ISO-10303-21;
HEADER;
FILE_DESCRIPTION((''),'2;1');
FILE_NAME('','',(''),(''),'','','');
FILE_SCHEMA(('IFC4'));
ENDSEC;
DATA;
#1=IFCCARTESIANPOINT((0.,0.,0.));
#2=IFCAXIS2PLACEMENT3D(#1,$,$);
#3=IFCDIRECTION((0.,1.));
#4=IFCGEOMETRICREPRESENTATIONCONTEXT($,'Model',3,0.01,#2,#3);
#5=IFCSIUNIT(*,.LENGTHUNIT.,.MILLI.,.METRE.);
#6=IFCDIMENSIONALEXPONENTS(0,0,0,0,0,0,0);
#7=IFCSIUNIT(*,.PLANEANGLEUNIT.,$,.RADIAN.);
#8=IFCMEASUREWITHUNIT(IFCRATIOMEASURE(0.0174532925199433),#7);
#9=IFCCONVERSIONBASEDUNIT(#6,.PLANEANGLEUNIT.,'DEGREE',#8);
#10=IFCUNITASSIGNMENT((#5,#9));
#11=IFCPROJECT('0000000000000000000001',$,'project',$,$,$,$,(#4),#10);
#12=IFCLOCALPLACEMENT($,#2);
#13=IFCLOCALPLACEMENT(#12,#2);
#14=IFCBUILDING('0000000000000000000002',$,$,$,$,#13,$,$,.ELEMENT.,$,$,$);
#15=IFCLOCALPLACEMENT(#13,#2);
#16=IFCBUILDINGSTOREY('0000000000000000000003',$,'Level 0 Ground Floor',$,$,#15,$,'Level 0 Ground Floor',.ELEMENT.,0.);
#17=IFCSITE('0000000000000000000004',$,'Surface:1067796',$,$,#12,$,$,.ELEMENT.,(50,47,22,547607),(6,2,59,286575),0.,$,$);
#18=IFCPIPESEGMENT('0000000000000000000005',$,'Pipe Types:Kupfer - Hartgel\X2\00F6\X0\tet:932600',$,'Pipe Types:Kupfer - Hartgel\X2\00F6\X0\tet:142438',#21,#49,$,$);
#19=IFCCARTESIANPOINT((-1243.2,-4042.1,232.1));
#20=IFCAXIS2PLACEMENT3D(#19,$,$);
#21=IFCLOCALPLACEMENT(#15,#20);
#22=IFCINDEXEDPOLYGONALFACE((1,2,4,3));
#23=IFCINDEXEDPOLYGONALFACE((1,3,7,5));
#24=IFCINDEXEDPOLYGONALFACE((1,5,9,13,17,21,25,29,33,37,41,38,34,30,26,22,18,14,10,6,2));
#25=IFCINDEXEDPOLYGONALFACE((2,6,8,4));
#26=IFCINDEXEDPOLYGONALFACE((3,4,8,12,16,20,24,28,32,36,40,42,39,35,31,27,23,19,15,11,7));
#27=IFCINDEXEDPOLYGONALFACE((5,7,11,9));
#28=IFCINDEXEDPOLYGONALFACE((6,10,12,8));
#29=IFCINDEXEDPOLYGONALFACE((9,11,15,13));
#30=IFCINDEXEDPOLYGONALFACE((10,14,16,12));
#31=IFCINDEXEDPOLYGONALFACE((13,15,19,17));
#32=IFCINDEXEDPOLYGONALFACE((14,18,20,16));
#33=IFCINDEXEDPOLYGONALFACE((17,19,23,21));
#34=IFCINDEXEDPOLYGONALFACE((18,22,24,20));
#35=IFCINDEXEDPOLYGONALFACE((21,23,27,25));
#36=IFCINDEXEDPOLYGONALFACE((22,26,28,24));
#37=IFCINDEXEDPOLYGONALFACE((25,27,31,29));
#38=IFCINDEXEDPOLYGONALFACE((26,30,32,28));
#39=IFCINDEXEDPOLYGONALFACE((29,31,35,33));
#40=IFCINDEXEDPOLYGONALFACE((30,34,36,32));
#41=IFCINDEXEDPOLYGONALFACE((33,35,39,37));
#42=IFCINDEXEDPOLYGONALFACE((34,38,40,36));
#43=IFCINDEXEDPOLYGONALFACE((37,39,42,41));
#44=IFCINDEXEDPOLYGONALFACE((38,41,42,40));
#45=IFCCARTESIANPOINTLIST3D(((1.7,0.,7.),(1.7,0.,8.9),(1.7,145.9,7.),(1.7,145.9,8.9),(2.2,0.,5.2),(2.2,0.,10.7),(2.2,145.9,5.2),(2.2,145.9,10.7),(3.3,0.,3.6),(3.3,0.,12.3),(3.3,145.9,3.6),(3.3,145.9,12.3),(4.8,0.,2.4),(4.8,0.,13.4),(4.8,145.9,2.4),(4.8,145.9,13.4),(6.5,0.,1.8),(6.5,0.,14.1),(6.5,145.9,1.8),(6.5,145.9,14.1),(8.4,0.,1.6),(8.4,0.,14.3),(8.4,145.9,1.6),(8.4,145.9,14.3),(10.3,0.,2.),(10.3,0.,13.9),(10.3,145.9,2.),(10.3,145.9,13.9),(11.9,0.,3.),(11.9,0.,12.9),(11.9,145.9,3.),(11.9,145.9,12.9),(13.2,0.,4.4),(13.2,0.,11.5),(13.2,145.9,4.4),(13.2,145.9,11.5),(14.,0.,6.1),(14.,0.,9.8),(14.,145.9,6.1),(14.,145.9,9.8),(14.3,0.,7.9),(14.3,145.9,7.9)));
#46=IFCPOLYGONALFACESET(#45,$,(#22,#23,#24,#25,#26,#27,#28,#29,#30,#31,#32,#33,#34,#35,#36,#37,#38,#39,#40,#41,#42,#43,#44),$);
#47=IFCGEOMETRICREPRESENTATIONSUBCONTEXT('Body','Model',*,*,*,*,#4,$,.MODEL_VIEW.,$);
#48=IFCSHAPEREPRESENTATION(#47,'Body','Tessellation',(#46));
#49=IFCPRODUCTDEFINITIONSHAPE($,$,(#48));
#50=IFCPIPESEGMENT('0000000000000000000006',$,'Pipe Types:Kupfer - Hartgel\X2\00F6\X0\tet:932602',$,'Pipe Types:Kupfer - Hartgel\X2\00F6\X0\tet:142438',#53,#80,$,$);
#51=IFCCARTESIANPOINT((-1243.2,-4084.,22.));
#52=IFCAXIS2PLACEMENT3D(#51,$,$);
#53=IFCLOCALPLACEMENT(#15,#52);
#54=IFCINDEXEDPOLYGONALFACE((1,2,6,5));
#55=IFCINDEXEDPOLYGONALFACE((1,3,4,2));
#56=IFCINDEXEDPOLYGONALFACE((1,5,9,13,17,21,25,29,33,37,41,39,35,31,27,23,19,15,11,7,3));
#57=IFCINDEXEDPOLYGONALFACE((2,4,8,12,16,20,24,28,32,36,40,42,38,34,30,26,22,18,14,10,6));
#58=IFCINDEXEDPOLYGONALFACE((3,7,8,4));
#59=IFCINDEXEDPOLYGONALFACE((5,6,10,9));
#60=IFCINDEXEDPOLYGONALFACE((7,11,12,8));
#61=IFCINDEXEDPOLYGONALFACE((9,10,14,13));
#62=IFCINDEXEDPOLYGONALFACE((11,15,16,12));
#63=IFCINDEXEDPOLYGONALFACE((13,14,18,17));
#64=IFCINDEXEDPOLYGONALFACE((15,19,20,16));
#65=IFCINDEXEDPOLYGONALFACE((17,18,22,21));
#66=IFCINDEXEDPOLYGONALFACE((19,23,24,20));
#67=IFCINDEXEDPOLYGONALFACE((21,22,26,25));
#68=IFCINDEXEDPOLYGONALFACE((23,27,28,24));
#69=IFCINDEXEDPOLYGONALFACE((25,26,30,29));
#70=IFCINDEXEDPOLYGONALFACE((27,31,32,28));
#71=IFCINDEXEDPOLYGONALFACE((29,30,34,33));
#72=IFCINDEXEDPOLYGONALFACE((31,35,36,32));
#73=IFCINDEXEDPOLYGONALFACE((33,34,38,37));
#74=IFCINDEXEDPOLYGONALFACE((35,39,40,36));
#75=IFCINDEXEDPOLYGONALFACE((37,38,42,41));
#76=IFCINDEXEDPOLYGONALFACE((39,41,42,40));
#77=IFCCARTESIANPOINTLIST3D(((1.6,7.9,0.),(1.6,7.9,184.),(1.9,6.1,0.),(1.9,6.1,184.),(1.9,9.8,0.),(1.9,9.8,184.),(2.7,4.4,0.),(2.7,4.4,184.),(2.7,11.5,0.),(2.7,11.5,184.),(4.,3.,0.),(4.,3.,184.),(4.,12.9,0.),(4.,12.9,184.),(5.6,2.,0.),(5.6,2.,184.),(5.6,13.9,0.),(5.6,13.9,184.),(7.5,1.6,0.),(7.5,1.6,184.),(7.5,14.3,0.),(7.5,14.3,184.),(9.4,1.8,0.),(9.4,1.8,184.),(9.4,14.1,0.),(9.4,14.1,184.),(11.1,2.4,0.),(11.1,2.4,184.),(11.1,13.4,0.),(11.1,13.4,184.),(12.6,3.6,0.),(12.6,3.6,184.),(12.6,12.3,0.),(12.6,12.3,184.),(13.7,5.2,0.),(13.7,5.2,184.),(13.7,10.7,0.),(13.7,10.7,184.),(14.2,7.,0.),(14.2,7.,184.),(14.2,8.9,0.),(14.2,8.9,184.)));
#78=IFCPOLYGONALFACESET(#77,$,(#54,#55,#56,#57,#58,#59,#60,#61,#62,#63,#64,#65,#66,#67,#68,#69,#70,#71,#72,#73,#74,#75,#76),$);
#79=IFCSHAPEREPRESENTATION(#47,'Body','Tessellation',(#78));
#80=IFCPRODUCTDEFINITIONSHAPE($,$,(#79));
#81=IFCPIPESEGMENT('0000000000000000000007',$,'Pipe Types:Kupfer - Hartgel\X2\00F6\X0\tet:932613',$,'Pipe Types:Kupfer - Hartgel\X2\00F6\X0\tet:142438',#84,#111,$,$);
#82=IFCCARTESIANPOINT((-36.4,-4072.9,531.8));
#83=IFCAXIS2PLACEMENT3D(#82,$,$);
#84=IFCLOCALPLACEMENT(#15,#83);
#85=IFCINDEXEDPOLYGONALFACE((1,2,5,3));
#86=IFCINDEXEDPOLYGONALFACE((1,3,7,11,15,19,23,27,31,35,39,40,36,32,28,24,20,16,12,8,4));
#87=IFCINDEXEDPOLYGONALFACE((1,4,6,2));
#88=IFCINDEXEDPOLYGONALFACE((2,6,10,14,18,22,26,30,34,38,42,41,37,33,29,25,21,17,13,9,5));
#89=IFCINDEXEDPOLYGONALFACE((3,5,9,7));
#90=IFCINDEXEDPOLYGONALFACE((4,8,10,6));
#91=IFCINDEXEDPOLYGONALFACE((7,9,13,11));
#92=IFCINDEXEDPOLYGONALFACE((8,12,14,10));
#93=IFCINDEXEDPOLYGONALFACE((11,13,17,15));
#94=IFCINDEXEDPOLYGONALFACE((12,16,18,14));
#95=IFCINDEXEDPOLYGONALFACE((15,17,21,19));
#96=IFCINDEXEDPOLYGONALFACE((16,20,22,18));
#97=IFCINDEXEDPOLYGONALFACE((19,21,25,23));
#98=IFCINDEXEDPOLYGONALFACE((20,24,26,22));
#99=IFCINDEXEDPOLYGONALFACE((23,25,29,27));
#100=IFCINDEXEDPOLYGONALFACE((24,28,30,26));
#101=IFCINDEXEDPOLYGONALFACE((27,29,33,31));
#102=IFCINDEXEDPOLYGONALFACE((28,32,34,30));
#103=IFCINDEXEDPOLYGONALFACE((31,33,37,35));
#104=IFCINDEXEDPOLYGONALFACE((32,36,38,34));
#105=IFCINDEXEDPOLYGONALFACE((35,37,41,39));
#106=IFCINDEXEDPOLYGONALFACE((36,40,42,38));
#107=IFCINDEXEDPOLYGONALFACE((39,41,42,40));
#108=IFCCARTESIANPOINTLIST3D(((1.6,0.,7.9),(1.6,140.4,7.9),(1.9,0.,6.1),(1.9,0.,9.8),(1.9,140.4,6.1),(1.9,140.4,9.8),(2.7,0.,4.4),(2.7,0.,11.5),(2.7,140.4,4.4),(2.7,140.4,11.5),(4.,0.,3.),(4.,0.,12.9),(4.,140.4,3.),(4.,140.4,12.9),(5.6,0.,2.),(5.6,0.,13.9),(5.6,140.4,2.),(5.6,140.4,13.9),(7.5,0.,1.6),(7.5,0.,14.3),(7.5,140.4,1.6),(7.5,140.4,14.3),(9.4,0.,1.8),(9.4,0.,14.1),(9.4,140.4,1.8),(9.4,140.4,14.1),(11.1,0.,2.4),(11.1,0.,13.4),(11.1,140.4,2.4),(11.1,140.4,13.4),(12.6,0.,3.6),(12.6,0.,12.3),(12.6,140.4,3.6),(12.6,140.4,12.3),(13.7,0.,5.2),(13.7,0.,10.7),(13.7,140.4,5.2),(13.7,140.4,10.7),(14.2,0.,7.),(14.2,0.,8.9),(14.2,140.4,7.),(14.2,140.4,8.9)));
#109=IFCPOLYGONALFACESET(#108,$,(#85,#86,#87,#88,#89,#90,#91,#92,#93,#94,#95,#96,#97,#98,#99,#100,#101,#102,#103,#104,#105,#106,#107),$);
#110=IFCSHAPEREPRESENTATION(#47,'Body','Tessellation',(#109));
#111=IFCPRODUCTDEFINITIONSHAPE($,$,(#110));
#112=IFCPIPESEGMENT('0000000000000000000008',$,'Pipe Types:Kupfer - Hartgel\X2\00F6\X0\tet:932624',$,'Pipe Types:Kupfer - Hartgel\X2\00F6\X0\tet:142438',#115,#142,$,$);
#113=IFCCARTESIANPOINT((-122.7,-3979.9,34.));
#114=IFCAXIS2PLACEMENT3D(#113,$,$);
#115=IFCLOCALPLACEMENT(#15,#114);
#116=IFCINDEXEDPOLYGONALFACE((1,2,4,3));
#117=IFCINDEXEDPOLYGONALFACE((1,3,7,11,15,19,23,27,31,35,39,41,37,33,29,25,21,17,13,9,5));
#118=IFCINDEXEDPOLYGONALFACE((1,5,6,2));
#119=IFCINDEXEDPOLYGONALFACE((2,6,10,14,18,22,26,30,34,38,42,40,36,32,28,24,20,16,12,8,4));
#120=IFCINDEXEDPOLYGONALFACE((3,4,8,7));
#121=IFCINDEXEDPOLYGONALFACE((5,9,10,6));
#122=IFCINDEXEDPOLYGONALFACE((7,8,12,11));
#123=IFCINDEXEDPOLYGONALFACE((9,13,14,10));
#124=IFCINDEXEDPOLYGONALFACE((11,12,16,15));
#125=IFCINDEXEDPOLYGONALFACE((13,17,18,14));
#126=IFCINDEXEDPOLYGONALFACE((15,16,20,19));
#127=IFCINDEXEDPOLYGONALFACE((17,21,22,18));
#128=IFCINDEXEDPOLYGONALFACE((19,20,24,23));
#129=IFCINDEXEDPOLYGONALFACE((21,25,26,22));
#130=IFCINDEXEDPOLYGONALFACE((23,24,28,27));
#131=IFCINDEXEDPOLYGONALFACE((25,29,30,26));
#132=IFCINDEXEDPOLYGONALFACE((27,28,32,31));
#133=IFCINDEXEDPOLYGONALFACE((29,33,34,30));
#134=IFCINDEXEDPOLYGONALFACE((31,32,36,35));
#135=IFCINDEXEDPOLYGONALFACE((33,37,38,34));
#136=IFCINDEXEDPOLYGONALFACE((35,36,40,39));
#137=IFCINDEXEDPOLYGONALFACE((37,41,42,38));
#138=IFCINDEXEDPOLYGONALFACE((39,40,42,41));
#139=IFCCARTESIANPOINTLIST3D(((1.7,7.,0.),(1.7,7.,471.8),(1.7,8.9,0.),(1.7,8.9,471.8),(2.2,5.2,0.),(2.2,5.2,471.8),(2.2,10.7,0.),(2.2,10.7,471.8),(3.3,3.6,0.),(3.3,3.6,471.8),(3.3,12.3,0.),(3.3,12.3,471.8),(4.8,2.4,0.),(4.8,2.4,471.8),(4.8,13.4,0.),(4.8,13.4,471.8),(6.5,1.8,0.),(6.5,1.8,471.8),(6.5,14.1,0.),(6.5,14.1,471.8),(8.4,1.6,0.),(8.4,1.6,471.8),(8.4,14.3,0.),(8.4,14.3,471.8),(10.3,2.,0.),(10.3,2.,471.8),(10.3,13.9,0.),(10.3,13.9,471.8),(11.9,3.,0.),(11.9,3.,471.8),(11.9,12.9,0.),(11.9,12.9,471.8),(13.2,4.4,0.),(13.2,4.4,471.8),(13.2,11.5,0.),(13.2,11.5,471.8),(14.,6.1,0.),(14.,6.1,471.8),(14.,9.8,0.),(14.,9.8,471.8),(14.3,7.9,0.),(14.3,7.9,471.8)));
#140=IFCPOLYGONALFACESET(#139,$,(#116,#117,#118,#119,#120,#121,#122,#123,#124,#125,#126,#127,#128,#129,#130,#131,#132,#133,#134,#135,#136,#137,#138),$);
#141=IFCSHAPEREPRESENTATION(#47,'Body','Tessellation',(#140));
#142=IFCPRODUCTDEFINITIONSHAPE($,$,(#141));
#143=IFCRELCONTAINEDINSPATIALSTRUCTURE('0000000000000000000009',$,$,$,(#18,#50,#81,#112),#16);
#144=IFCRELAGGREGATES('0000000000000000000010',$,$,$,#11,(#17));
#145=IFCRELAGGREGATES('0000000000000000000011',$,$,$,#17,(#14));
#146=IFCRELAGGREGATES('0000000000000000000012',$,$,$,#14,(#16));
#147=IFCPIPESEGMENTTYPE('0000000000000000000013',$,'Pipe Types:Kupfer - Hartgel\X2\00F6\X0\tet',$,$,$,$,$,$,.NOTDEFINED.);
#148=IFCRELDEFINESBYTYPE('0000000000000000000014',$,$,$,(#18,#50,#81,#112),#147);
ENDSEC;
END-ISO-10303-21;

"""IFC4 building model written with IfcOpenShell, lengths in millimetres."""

from ifc_helpers import new_model, entity, si_unit, converted_unit, direction, frame, frame_2d, origin, origin_2d_with_axis, place, context, subcontext, project, spatial, circle, extrude, type_object, element, save


model = new_model("IFC4")

# Units and contexts
model_context = context("Model", 3, precision=0.01, world=origin(), true_north=direction((0.0, 1.0)))
body_context = subcontext(model_context, "Body", "Model", "MODEL_VIEW")
ifc_project = project(units=[si_unit("LENGTHUNIT", "METRE", prefix="MILLI"), converted_unit("PLANEANGLEUNIT", "DEGREE", entity("IfcRatioMeasure", 0.0174532925199433), si_unit("PLANEANGLEUNIT", "RADIAN"), dimensions=[0, 0, 0, 0, 0, 0, 0])], contexts=[model_context])

# Site, building, storey
site_placement = place(None, origin())
site = spatial("IfcSite", under=ifc_project, at=site_placement, Name="Surface:1067796", CompositionType="ELEMENT", RefLatitude=(50, 47, 22, 547607), RefLongitude=(6, 2, 59, 286575), RefElevation=0.0)
building_placement = place(site_placement, origin())
building = spatial("IfcBuilding", under=site, at=building_placement, CompositionType="ELEMENT")
storey_placement = place(building_placement, origin())
storey = spatial("IfcBuildingStorey", under=building, at=storey_placement, Name="Level 0 Ground Floor", LongName="Level 0 Ground Floor", CompositionType="ELEMENT", Elevation=0.0)

# Pipe segments
pipe_segment_type_1 = type_object("IfcPipeSegmentType", Name="Pipe Types:Kupfer - Hartgelötet", PredefinedType="NOTDEFINED")
pipe_segment_1_placement = place(storey_placement, frame((-1243.2, -4042.1, 232.1)))
element("IfcPipeSegment", 1, at=pipe_segment_1_placement, inside=storey, type_object=pipe_segment_type_1, Name="Pipe Types:Kupfer - Hartgelötet:932600", ObjectType="Pipe Types:Kupfer - Hartgelötet:142438", context=body_context, shape_type="SweptSolid", body=[
    extrude(circle(Radius=6.3, at=frame_2d((0.0, 0.0), x_axis=(1.0, 0.0))), frame((7.9, 0.0, 7.9), z_axis=(0.0, 1.0, 0.0), x_axis=(1.0, 0.0, 0.0)), (0.0, 0.0, 1.0), 145.9),
])
pipe_segment_2_placement = place(storey_placement, frame((-1243.2, -4084.0, 22.0)))
element("IfcPipeSegment", 2, at=pipe_segment_2_placement, inside=storey, type_object=pipe_segment_type_1, Name="Pipe Types:Kupfer - Hartgelötet:932602", ObjectType="Pipe Types:Kupfer - Hartgelötet:142438", context=body_context, shape_type="SweptSolid", body=[
    extrude(circle(Radius=6.3, at=frame_2d((0.0, 0.0), x_axis=(1.0, 0.0))), frame((7.9, 7.9, 0.0), z_axis=(0.0, 0.0, 1.0), x_axis=(-1.0, 0.0, 0.0)), (0.0, 0.0, 1.0), 184.0),
])
pipe_segment_3_placement = place(storey_placement, frame((-36.4, -4072.9, 531.8)))
element("IfcPipeSegment", 3, at=pipe_segment_3_placement, inside=storey, type_object=pipe_segment_type_1, Name="Pipe Types:Kupfer - Hartgelötet:932613", ObjectType="Pipe Types:Kupfer - Hartgelötet:142438", context=body_context, shape_type="SweptSolid", body=[
    extrude(circle(Radius=6.3, at=frame_2d((0.0, 0.0), x_axis=(1.0, 0.0))), frame((7.9, 0.0, 7.9), z_axis=(0.0, 1.0, 0.0), x_axis=(-1.0, 0.0, 0.0)), (0.0, 0.0, 1.0), 140.4),
])
pipe_segment_4_placement = place(storey_placement, frame((-122.7, -3979.9, 34.0)))
element("IfcPipeSegment", 4, at=pipe_segment_4_placement, inside=storey, type_object=pipe_segment_type_1, Name="Pipe Types:Kupfer - Hartgelötet:932624", ObjectType="Pipe Types:Kupfer - Hartgelötet:142438", context=body_context, shape_type="SweptSolid", body=[
    extrude(circle(Radius=6.3, at=origin_2d_with_axis()), frame((7.9, 7.9, 0.0)), (0.0, 0.0, 1.0), 471.8),
])

save(model, "model.ifc")
